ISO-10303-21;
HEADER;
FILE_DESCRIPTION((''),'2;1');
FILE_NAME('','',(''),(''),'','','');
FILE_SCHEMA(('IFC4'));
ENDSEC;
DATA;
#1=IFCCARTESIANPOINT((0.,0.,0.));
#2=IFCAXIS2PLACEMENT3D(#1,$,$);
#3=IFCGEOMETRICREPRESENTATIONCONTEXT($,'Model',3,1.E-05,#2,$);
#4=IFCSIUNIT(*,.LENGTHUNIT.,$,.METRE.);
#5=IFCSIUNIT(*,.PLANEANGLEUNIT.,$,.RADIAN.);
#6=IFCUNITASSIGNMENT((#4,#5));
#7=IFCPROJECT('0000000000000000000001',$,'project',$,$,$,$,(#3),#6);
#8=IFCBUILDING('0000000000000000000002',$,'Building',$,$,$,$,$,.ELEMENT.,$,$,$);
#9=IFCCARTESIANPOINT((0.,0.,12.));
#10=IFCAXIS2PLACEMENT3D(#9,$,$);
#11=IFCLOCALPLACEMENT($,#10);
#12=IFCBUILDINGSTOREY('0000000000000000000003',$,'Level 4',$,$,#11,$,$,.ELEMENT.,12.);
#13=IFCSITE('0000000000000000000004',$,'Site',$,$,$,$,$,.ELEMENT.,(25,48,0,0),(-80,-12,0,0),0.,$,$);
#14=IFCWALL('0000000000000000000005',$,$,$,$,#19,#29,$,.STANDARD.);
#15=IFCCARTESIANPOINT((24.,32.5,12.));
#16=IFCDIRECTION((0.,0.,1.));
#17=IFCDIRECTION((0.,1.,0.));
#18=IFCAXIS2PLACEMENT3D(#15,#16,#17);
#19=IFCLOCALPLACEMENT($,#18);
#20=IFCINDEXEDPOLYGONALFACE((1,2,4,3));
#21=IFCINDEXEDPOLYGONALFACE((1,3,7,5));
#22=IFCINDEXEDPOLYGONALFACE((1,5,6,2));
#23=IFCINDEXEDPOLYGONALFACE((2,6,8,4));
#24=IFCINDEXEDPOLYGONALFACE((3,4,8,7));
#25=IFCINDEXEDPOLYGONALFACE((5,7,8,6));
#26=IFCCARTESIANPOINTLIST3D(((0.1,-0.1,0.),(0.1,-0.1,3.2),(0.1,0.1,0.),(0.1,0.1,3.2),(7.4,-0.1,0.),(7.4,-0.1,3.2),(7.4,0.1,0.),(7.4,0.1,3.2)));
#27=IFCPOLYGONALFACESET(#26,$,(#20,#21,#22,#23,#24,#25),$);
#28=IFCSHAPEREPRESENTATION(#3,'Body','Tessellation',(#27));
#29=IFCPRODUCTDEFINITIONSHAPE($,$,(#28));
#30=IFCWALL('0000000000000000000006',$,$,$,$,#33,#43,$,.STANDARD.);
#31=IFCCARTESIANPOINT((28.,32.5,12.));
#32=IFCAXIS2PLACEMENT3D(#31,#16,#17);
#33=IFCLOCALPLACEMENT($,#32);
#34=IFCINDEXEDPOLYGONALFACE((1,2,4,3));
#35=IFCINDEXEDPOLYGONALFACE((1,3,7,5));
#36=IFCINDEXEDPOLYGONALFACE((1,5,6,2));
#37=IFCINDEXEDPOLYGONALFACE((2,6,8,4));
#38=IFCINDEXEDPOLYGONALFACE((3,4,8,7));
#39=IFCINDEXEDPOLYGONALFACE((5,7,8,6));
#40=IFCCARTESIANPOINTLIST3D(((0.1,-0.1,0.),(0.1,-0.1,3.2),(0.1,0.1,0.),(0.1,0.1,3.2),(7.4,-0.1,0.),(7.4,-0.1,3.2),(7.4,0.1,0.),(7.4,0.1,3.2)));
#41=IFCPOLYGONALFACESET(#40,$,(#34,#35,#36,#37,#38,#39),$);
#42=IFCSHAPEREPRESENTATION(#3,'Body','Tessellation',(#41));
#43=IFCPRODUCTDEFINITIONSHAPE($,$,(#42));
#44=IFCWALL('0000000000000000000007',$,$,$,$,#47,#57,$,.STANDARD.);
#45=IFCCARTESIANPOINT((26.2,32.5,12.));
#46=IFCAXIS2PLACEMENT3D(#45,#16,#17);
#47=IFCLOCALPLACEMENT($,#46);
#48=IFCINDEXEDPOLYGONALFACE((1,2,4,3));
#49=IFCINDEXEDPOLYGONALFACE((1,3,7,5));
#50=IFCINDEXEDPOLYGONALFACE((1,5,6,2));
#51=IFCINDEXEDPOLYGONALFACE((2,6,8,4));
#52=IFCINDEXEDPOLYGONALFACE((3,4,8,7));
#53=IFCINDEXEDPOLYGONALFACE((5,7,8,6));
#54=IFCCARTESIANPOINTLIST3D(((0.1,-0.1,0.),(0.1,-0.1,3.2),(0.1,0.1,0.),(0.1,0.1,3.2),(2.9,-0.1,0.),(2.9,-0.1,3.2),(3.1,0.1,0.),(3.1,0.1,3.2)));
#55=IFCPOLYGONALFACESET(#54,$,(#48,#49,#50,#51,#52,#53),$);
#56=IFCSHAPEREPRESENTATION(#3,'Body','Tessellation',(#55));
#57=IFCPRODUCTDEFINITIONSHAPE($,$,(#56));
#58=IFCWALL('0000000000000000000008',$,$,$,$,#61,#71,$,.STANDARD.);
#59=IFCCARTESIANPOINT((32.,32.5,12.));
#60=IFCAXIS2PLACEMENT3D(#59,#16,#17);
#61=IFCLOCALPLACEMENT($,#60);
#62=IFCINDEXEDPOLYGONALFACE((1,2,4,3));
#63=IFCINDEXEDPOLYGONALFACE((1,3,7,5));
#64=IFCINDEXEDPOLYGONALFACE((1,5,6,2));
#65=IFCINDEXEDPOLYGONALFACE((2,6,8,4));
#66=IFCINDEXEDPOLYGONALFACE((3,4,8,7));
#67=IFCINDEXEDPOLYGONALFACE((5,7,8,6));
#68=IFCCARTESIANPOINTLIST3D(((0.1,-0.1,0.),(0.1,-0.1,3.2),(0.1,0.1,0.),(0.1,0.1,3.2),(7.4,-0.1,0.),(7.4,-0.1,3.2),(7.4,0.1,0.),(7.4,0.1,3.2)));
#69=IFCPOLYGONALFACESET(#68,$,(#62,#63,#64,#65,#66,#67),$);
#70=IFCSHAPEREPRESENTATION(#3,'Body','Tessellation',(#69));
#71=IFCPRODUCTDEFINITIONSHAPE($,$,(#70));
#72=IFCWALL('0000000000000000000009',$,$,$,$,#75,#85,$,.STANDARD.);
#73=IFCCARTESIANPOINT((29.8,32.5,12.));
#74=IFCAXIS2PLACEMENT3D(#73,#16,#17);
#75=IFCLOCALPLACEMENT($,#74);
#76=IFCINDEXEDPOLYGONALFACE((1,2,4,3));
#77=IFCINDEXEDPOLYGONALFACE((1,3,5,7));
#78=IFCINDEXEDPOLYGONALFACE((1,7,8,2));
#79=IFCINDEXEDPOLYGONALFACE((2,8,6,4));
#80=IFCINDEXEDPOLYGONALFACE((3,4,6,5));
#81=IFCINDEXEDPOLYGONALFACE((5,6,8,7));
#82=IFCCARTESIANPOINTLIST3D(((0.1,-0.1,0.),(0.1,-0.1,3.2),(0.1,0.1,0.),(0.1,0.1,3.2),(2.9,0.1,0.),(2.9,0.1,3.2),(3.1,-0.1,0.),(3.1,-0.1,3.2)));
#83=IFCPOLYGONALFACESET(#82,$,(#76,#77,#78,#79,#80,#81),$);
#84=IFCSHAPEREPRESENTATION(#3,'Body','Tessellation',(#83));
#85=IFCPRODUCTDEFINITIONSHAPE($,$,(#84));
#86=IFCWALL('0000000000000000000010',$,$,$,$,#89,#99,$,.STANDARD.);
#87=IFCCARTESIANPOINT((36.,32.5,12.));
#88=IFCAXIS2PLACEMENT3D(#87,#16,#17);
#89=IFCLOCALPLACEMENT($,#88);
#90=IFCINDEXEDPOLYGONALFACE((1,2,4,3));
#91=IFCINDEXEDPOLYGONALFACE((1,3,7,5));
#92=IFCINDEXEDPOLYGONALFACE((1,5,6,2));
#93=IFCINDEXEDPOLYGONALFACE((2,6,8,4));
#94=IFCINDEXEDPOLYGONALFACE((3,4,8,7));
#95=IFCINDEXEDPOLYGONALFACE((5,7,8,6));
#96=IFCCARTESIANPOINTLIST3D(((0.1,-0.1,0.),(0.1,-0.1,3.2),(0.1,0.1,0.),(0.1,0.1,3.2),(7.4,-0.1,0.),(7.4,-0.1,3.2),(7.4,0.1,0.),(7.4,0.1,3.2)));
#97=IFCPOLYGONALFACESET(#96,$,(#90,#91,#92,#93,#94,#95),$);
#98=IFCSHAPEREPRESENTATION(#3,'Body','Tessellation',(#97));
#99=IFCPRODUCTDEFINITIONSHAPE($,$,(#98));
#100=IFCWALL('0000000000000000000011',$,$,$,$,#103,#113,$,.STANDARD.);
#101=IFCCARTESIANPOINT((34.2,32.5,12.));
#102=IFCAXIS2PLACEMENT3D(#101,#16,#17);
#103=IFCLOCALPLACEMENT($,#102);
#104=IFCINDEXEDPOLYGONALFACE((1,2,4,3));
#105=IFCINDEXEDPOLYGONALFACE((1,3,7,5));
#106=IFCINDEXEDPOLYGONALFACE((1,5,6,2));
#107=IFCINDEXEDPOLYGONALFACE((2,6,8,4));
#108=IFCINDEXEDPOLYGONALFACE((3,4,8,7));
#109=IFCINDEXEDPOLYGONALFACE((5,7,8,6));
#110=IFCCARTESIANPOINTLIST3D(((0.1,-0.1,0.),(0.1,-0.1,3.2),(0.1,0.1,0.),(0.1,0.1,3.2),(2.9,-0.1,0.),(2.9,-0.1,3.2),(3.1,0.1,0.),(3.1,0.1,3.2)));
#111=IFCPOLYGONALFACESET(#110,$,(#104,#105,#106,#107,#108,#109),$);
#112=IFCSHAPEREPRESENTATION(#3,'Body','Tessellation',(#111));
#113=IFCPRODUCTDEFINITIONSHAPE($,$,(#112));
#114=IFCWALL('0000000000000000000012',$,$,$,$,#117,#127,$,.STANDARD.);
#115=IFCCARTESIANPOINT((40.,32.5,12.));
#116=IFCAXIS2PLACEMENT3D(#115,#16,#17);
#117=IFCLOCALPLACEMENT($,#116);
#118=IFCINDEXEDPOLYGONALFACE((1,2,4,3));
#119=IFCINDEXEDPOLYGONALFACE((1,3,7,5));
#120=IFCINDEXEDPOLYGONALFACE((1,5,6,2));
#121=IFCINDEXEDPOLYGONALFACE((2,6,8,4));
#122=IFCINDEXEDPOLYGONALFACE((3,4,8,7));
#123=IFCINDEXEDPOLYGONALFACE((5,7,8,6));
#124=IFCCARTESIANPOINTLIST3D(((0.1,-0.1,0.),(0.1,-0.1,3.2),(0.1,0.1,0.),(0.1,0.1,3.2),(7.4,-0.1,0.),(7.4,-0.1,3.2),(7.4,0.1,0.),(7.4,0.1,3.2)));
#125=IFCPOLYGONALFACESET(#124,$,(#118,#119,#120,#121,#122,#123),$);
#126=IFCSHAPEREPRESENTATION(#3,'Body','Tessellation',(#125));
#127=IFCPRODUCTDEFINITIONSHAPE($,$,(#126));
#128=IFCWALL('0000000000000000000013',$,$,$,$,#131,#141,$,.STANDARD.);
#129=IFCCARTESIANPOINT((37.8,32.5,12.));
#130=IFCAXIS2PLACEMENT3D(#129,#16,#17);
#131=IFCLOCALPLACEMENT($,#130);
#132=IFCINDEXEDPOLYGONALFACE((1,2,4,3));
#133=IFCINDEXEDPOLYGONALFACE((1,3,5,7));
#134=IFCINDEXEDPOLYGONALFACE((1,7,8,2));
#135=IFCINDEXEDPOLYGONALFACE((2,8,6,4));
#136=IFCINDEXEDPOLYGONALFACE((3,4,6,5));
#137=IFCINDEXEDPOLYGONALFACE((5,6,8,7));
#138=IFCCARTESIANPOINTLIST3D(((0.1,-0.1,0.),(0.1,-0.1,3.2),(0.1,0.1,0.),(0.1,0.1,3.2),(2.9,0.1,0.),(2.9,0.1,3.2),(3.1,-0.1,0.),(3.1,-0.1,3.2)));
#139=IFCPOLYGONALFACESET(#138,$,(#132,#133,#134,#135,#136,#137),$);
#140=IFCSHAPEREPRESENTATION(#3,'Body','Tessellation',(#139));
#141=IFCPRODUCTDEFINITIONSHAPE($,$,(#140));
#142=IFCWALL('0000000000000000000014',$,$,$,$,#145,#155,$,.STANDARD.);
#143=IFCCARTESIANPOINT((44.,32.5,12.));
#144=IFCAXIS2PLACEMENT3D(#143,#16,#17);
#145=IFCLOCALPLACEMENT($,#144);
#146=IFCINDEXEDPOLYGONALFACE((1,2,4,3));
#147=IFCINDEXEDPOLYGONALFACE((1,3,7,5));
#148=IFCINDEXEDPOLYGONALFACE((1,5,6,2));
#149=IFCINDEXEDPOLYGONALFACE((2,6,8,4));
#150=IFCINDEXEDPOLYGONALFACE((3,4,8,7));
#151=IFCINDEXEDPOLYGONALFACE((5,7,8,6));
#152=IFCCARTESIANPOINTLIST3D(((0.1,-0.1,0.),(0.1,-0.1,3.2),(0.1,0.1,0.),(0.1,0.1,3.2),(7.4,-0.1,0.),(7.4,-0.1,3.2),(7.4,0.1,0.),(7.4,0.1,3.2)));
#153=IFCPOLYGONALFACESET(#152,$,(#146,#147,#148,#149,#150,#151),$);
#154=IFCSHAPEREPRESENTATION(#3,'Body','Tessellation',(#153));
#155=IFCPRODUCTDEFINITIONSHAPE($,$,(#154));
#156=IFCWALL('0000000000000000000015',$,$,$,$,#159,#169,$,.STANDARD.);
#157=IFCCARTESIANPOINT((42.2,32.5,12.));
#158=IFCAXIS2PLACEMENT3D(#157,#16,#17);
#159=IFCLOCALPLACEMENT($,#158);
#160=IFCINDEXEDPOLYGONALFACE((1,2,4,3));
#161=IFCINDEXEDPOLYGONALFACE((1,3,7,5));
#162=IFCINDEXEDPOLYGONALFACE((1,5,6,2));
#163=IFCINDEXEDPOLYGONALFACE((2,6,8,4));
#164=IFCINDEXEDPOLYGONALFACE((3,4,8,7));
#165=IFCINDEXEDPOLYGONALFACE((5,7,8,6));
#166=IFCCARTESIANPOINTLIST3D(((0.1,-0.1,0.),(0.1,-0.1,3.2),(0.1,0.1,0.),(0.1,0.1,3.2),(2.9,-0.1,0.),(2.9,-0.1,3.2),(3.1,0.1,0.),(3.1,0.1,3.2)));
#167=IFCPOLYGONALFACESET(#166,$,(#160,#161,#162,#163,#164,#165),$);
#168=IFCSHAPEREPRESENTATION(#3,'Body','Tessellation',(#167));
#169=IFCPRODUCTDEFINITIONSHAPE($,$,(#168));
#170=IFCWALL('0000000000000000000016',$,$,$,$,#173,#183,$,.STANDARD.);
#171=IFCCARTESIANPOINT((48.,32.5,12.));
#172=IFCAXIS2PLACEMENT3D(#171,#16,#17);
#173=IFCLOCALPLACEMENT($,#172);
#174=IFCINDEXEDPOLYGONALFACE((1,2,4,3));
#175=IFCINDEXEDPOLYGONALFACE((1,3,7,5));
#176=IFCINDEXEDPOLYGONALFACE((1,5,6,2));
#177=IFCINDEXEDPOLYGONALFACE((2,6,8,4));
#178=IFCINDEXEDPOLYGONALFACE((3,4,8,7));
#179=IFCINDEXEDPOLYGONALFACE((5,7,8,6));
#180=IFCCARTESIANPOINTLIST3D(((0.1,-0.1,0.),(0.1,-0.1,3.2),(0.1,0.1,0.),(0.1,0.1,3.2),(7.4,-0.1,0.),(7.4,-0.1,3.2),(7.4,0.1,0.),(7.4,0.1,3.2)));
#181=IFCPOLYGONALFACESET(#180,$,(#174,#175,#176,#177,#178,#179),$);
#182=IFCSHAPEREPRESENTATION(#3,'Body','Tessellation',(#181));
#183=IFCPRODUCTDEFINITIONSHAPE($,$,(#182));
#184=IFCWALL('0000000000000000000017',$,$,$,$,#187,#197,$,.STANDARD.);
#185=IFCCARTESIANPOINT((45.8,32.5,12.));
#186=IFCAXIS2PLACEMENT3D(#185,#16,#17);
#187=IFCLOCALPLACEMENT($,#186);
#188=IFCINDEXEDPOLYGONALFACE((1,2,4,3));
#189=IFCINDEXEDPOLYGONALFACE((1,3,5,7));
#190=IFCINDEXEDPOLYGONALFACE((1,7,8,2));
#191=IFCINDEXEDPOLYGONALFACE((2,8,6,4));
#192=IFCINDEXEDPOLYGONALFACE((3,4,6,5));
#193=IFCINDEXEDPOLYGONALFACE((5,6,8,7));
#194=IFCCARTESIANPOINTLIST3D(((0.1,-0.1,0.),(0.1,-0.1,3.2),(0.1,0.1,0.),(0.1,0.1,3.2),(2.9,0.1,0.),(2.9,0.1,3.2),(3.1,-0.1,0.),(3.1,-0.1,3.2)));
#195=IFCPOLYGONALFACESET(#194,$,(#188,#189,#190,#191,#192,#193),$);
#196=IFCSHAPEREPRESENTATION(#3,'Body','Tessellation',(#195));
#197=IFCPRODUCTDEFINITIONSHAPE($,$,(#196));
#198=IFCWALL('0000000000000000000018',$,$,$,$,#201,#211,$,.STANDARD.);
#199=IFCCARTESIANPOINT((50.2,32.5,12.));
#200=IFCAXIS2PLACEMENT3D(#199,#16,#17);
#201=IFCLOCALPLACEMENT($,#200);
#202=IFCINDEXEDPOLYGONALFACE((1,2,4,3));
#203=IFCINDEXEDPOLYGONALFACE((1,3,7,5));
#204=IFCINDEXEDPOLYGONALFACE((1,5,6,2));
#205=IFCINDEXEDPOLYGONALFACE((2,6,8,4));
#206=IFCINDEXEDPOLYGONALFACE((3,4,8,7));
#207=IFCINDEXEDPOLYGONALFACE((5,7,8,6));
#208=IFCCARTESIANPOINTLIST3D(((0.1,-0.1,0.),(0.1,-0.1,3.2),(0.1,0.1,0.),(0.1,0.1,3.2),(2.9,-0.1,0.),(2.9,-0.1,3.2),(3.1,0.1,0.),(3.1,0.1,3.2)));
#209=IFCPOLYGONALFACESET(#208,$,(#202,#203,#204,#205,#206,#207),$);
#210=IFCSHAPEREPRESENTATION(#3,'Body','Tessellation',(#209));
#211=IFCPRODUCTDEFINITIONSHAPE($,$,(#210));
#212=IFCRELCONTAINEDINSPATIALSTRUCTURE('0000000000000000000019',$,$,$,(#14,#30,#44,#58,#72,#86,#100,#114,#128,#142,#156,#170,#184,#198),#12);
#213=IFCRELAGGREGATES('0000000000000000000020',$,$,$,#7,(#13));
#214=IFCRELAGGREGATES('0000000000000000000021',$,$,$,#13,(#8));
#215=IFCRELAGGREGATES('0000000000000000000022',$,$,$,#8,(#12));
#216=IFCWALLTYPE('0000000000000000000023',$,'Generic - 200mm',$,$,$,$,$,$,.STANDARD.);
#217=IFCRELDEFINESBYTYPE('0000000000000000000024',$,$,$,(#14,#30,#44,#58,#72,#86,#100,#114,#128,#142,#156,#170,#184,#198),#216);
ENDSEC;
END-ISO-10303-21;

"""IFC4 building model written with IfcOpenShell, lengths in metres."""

from ifc_helpers import new_model, si_unit, frame, origin, place, context, project, spatial, polyline, outline, extrude, type_object, element, save


model = new_model("IFC4")

# Units and contexts
model_context = context("Model", 3, precision=1e-05, world=origin())
ifc_project = project(units=[si_unit("LENGTHUNIT", "METRE"), si_unit("PLANEANGLEUNIT", "RADIAN")], contexts=[model_context])

# Site, building, storey
site = spatial("IfcSite", under=ifc_project, Name="Site", CompositionType="ELEMENT", RefLatitude=(25, 48, 0, 0), RefLongitude=(-80, -12, 0, 0), RefElevation=0.0)
building = spatial("IfcBuilding", under=site, Name="Building", CompositionType="ELEMENT")
storey_placement = place(None, frame((0.0, 0.0, 12.0)))
storey = spatial("IfcBuildingStorey", under=building, at=storey_placement, Name="Level 4", CompositionType="ELEMENT", Elevation=12.0)

# Shared definitions
wall_type = type_object("IfcWallType", Name="Generic - 200mm", PredefinedType="STANDARD")

# Walls
for number, where, z_axis, x_axis in (
    (1, (24.0, 32.5, 12.0), (0.0, 0.0, 1.0), (0.0, 1.0, 0.0)),
    (2, (28.0, 32.5, 12.0), (0.0, 0.0, 1.0), (0.0, 1.0, 0.0)),
):
    element("IfcWall", number, at=place(None, frame(where, z_axis=z_axis, x_axis=x_axis)), inside=storey, type_object=wall_type, PredefinedType="STANDARD", context=model_context, shape_type="SweptSolid", body=[
        extrude(outline(polyline([(0.1, -0.1), (7.4, -0.1), (7.4, 0.1), (0.1, 0.1), (0.1, -0.1)])), origin(), (0.0, 0.0, 1.0), 3.2),
    ])
wall_1_placement = place(None, frame((26.2, 32.5, 12.0), z_axis=(0.0, 0.0, 1.0), x_axis=(0.0, 1.0, 0.0)))
element("IfcWall", 3, at=wall_1_placement, inside=storey, type_object=wall_type, PredefinedType="STANDARD", context=model_context, shape_type="SweptSolid", body=[
    extrude(outline(polyline([(0.1, -0.1), (2.9, -0.1), (3.1, 0.1), (0.1, 0.1), (0.1, -0.1)])), origin(), (0.0, 0.0, 1.0), 3.2),
])
wall_2_placement = place(None, frame((32.0, 32.5, 12.0), z_axis=(0.0, 0.0, 1.0), x_axis=(0.0, 1.0, 0.0)))
element("IfcWall", 4, at=wall_2_placement, inside=storey, type_object=wall_type, PredefinedType="STANDARD", context=model_context, shape_type="SweptSolid", body=[
    extrude(outline(polyline([(0.1, -0.1), (7.4, -0.1), (7.4, 0.1), (0.1, 0.1), (0.1, -0.1)])), origin(), (0.0, 0.0, 1.0), 3.2),
])
wall_3_placement = place(None, frame((29.8, 32.5, 12.0), z_axis=(0.0, 0.0, 1.0), x_axis=(0.0, 1.0, 0.0)))
element("IfcWall", 5, at=wall_3_placement, inside=storey, type_object=wall_type, PredefinedType="STANDARD", context=model_context, shape_type="SweptSolid", body=[
    extrude(outline(polyline([(0.1, -0.1), (3.1, -0.1), (2.9, 0.1), (0.1, 0.1), (0.1, -0.1)])), origin(), (0.0, 0.0, 1.0), 3.2),
])
wall_4_placement = place(None, frame((36.0, 32.5, 12.0), z_axis=(0.0, 0.0, 1.0), x_axis=(0.0, 1.0, 0.0)))
element("IfcWall", 6, at=wall_4_placement, inside=storey, type_object=wall_type, PredefinedType="STANDARD", context=model_context, shape_type="SweptSolid", body=[
    extrude(outline(polyline([(0.1, -0.1), (7.4, -0.1), (7.4, 0.1), (0.1, 0.1), (0.1, -0.1)])), origin(), (0.0, 0.0, 1.0), 3.2),
])
wall_5_placement = place(None, frame((34.2, 32.5, 12.0), z_axis=(0.0, 0.0, 1.0), x_axis=(0.0, 1.0, 0.0)))
element("IfcWall", 7, at=wall_5_placement, inside=storey, type_object=wall_type, PredefinedType="STANDARD", context=model_context, shape_type="SweptSolid", body=[
    extrude(outline(polyline([(0.1, -0.1), (2.9, -0.1), (3.1, 0.1), (0.1, 0.1), (0.1, -0.1)])), origin(), (0.0, 0.0, 1.0), 3.2),
])
wall_6_placement = place(None, frame((40.0, 32.5, 12.0), z_axis=(0.0, 0.0, 1.0), x_axis=(0.0, 1.0, 0.0)))
element("IfcWall", 8, at=wall_6_placement, inside=storey, type_object=wall_type, PredefinedType="STANDARD", context=model_context, shape_type="SweptSolid", body=[
    extrude(outline(polyline([(0.1, -0.1), (7.4, -0.1), (7.4, 0.1), (0.1, 0.1), (0.1, -0.1)])), origin(), (0.0, 0.0, 1.0), 3.2),
])
wall_7_placement = place(None, frame((37.8, 32.5, 12.0), z_axis=(0.0, 0.0, 1.0), x_axis=(0.0, 1.0, 0.0)))
element("IfcWall", 9, at=wall_7_placement, inside=storey, type_object=wall_type, PredefinedType="STANDARD", context=model_context, shape_type="SweptSolid", body=[
    extrude(outline(polyline([(0.1, -0.1), (3.1, -0.1), (2.9, 0.1), (0.1, 0.1), (0.1, -0.1)])), origin(), (0.0, 0.0, 1.0), 3.2),
])
wall_8_placement = place(None, frame((44.0, 32.5, 12.0), z_axis=(0.0, 0.0, 1.0), x_axis=(0.0, 1.0, 0.0)))
element("IfcWall", 10, at=wall_8_placement, inside=storey, type_object=wall_type, PredefinedType="STANDARD", context=model_context, shape_type="SweptSolid", body=[
    extrude(outline(polyline([(0.1, -0.1), (7.4, -0.1), (7.4, 0.1), (0.1, 0.1), (0.1, -0.1)])), origin(), (0.0, 0.0, 1.0), 3.2),
])
wall_9_placement = place(None, frame((42.2, 32.5, 12.0), z_axis=(0.0, 0.0, 1.0), x_axis=(0.0, 1.0, 0.0)))
element("IfcWall", 11, at=wall_9_placement, inside=storey, type_object=wall_type, PredefinedType="STANDARD", context=model_context, shape_type="SweptSolid", body=[
    extrude(outline(polyline([(0.1, -0.1), (2.9, -0.1), (3.1, 0.1), (0.1, 0.1), (0.1, -0.1)])), origin(), (0.0, 0.0, 1.0), 3.2),
])
wall_10_placement = place(None, frame((48.0, 32.5, 12.0), z_axis=(0.0, 0.0, 1.0), x_axis=(0.0, 1.0, 0.0)))
element("IfcWall", 12, at=wall_10_placement, inside=storey, type_object=wall_type, PredefinedType="STANDARD", context=model_context, shape_type="SweptSolid", body=[
    extrude(outline(polyline([(0.1, -0.1), (7.4, -0.1), (7.4, 0.1), (0.1, 0.1), (0.1, -0.1)])), origin(), (0.0, 0.0, 1.0), 3.2),
])
wall_11_placement = place(None, frame((45.8, 32.5, 12.0), z_axis=(0.0, 0.0, 1.0), x_axis=(0.0, 1.0, 0.0)))
element("IfcWall", 13, at=wall_11_placement, inside=storey, type_object=wall_type, PredefinedType="STANDARD", context=model_context, shape_type="SweptSolid", body=[
    extrude(outline(polyline([(0.1, -0.1), (3.1, -0.1), (2.9, 0.1), (0.1, 0.1), (0.1, -0.1)])), origin(), (0.0, 0.0, 1.0), 3.2),
])
wall_12_placement = place(None, frame((50.2, 32.5, 12.0), z_axis=(0.0, 0.0, 1.0), x_axis=(0.0, 1.0, 0.0)))
element("IfcWall", 14, at=wall_12_placement, inside=storey, type_object=wall_type, PredefinedType="STANDARD", context=model_context, shape_type="SweptSolid", body=[
    extrude(outline(polyline([(0.1, -0.1), (2.9, -0.1), (3.1, 0.1), (0.1, 0.1), (0.1, -0.1)])), origin(), (0.0, 0.0, 1.0), 3.2),
])

save(model, "model.ifc")
